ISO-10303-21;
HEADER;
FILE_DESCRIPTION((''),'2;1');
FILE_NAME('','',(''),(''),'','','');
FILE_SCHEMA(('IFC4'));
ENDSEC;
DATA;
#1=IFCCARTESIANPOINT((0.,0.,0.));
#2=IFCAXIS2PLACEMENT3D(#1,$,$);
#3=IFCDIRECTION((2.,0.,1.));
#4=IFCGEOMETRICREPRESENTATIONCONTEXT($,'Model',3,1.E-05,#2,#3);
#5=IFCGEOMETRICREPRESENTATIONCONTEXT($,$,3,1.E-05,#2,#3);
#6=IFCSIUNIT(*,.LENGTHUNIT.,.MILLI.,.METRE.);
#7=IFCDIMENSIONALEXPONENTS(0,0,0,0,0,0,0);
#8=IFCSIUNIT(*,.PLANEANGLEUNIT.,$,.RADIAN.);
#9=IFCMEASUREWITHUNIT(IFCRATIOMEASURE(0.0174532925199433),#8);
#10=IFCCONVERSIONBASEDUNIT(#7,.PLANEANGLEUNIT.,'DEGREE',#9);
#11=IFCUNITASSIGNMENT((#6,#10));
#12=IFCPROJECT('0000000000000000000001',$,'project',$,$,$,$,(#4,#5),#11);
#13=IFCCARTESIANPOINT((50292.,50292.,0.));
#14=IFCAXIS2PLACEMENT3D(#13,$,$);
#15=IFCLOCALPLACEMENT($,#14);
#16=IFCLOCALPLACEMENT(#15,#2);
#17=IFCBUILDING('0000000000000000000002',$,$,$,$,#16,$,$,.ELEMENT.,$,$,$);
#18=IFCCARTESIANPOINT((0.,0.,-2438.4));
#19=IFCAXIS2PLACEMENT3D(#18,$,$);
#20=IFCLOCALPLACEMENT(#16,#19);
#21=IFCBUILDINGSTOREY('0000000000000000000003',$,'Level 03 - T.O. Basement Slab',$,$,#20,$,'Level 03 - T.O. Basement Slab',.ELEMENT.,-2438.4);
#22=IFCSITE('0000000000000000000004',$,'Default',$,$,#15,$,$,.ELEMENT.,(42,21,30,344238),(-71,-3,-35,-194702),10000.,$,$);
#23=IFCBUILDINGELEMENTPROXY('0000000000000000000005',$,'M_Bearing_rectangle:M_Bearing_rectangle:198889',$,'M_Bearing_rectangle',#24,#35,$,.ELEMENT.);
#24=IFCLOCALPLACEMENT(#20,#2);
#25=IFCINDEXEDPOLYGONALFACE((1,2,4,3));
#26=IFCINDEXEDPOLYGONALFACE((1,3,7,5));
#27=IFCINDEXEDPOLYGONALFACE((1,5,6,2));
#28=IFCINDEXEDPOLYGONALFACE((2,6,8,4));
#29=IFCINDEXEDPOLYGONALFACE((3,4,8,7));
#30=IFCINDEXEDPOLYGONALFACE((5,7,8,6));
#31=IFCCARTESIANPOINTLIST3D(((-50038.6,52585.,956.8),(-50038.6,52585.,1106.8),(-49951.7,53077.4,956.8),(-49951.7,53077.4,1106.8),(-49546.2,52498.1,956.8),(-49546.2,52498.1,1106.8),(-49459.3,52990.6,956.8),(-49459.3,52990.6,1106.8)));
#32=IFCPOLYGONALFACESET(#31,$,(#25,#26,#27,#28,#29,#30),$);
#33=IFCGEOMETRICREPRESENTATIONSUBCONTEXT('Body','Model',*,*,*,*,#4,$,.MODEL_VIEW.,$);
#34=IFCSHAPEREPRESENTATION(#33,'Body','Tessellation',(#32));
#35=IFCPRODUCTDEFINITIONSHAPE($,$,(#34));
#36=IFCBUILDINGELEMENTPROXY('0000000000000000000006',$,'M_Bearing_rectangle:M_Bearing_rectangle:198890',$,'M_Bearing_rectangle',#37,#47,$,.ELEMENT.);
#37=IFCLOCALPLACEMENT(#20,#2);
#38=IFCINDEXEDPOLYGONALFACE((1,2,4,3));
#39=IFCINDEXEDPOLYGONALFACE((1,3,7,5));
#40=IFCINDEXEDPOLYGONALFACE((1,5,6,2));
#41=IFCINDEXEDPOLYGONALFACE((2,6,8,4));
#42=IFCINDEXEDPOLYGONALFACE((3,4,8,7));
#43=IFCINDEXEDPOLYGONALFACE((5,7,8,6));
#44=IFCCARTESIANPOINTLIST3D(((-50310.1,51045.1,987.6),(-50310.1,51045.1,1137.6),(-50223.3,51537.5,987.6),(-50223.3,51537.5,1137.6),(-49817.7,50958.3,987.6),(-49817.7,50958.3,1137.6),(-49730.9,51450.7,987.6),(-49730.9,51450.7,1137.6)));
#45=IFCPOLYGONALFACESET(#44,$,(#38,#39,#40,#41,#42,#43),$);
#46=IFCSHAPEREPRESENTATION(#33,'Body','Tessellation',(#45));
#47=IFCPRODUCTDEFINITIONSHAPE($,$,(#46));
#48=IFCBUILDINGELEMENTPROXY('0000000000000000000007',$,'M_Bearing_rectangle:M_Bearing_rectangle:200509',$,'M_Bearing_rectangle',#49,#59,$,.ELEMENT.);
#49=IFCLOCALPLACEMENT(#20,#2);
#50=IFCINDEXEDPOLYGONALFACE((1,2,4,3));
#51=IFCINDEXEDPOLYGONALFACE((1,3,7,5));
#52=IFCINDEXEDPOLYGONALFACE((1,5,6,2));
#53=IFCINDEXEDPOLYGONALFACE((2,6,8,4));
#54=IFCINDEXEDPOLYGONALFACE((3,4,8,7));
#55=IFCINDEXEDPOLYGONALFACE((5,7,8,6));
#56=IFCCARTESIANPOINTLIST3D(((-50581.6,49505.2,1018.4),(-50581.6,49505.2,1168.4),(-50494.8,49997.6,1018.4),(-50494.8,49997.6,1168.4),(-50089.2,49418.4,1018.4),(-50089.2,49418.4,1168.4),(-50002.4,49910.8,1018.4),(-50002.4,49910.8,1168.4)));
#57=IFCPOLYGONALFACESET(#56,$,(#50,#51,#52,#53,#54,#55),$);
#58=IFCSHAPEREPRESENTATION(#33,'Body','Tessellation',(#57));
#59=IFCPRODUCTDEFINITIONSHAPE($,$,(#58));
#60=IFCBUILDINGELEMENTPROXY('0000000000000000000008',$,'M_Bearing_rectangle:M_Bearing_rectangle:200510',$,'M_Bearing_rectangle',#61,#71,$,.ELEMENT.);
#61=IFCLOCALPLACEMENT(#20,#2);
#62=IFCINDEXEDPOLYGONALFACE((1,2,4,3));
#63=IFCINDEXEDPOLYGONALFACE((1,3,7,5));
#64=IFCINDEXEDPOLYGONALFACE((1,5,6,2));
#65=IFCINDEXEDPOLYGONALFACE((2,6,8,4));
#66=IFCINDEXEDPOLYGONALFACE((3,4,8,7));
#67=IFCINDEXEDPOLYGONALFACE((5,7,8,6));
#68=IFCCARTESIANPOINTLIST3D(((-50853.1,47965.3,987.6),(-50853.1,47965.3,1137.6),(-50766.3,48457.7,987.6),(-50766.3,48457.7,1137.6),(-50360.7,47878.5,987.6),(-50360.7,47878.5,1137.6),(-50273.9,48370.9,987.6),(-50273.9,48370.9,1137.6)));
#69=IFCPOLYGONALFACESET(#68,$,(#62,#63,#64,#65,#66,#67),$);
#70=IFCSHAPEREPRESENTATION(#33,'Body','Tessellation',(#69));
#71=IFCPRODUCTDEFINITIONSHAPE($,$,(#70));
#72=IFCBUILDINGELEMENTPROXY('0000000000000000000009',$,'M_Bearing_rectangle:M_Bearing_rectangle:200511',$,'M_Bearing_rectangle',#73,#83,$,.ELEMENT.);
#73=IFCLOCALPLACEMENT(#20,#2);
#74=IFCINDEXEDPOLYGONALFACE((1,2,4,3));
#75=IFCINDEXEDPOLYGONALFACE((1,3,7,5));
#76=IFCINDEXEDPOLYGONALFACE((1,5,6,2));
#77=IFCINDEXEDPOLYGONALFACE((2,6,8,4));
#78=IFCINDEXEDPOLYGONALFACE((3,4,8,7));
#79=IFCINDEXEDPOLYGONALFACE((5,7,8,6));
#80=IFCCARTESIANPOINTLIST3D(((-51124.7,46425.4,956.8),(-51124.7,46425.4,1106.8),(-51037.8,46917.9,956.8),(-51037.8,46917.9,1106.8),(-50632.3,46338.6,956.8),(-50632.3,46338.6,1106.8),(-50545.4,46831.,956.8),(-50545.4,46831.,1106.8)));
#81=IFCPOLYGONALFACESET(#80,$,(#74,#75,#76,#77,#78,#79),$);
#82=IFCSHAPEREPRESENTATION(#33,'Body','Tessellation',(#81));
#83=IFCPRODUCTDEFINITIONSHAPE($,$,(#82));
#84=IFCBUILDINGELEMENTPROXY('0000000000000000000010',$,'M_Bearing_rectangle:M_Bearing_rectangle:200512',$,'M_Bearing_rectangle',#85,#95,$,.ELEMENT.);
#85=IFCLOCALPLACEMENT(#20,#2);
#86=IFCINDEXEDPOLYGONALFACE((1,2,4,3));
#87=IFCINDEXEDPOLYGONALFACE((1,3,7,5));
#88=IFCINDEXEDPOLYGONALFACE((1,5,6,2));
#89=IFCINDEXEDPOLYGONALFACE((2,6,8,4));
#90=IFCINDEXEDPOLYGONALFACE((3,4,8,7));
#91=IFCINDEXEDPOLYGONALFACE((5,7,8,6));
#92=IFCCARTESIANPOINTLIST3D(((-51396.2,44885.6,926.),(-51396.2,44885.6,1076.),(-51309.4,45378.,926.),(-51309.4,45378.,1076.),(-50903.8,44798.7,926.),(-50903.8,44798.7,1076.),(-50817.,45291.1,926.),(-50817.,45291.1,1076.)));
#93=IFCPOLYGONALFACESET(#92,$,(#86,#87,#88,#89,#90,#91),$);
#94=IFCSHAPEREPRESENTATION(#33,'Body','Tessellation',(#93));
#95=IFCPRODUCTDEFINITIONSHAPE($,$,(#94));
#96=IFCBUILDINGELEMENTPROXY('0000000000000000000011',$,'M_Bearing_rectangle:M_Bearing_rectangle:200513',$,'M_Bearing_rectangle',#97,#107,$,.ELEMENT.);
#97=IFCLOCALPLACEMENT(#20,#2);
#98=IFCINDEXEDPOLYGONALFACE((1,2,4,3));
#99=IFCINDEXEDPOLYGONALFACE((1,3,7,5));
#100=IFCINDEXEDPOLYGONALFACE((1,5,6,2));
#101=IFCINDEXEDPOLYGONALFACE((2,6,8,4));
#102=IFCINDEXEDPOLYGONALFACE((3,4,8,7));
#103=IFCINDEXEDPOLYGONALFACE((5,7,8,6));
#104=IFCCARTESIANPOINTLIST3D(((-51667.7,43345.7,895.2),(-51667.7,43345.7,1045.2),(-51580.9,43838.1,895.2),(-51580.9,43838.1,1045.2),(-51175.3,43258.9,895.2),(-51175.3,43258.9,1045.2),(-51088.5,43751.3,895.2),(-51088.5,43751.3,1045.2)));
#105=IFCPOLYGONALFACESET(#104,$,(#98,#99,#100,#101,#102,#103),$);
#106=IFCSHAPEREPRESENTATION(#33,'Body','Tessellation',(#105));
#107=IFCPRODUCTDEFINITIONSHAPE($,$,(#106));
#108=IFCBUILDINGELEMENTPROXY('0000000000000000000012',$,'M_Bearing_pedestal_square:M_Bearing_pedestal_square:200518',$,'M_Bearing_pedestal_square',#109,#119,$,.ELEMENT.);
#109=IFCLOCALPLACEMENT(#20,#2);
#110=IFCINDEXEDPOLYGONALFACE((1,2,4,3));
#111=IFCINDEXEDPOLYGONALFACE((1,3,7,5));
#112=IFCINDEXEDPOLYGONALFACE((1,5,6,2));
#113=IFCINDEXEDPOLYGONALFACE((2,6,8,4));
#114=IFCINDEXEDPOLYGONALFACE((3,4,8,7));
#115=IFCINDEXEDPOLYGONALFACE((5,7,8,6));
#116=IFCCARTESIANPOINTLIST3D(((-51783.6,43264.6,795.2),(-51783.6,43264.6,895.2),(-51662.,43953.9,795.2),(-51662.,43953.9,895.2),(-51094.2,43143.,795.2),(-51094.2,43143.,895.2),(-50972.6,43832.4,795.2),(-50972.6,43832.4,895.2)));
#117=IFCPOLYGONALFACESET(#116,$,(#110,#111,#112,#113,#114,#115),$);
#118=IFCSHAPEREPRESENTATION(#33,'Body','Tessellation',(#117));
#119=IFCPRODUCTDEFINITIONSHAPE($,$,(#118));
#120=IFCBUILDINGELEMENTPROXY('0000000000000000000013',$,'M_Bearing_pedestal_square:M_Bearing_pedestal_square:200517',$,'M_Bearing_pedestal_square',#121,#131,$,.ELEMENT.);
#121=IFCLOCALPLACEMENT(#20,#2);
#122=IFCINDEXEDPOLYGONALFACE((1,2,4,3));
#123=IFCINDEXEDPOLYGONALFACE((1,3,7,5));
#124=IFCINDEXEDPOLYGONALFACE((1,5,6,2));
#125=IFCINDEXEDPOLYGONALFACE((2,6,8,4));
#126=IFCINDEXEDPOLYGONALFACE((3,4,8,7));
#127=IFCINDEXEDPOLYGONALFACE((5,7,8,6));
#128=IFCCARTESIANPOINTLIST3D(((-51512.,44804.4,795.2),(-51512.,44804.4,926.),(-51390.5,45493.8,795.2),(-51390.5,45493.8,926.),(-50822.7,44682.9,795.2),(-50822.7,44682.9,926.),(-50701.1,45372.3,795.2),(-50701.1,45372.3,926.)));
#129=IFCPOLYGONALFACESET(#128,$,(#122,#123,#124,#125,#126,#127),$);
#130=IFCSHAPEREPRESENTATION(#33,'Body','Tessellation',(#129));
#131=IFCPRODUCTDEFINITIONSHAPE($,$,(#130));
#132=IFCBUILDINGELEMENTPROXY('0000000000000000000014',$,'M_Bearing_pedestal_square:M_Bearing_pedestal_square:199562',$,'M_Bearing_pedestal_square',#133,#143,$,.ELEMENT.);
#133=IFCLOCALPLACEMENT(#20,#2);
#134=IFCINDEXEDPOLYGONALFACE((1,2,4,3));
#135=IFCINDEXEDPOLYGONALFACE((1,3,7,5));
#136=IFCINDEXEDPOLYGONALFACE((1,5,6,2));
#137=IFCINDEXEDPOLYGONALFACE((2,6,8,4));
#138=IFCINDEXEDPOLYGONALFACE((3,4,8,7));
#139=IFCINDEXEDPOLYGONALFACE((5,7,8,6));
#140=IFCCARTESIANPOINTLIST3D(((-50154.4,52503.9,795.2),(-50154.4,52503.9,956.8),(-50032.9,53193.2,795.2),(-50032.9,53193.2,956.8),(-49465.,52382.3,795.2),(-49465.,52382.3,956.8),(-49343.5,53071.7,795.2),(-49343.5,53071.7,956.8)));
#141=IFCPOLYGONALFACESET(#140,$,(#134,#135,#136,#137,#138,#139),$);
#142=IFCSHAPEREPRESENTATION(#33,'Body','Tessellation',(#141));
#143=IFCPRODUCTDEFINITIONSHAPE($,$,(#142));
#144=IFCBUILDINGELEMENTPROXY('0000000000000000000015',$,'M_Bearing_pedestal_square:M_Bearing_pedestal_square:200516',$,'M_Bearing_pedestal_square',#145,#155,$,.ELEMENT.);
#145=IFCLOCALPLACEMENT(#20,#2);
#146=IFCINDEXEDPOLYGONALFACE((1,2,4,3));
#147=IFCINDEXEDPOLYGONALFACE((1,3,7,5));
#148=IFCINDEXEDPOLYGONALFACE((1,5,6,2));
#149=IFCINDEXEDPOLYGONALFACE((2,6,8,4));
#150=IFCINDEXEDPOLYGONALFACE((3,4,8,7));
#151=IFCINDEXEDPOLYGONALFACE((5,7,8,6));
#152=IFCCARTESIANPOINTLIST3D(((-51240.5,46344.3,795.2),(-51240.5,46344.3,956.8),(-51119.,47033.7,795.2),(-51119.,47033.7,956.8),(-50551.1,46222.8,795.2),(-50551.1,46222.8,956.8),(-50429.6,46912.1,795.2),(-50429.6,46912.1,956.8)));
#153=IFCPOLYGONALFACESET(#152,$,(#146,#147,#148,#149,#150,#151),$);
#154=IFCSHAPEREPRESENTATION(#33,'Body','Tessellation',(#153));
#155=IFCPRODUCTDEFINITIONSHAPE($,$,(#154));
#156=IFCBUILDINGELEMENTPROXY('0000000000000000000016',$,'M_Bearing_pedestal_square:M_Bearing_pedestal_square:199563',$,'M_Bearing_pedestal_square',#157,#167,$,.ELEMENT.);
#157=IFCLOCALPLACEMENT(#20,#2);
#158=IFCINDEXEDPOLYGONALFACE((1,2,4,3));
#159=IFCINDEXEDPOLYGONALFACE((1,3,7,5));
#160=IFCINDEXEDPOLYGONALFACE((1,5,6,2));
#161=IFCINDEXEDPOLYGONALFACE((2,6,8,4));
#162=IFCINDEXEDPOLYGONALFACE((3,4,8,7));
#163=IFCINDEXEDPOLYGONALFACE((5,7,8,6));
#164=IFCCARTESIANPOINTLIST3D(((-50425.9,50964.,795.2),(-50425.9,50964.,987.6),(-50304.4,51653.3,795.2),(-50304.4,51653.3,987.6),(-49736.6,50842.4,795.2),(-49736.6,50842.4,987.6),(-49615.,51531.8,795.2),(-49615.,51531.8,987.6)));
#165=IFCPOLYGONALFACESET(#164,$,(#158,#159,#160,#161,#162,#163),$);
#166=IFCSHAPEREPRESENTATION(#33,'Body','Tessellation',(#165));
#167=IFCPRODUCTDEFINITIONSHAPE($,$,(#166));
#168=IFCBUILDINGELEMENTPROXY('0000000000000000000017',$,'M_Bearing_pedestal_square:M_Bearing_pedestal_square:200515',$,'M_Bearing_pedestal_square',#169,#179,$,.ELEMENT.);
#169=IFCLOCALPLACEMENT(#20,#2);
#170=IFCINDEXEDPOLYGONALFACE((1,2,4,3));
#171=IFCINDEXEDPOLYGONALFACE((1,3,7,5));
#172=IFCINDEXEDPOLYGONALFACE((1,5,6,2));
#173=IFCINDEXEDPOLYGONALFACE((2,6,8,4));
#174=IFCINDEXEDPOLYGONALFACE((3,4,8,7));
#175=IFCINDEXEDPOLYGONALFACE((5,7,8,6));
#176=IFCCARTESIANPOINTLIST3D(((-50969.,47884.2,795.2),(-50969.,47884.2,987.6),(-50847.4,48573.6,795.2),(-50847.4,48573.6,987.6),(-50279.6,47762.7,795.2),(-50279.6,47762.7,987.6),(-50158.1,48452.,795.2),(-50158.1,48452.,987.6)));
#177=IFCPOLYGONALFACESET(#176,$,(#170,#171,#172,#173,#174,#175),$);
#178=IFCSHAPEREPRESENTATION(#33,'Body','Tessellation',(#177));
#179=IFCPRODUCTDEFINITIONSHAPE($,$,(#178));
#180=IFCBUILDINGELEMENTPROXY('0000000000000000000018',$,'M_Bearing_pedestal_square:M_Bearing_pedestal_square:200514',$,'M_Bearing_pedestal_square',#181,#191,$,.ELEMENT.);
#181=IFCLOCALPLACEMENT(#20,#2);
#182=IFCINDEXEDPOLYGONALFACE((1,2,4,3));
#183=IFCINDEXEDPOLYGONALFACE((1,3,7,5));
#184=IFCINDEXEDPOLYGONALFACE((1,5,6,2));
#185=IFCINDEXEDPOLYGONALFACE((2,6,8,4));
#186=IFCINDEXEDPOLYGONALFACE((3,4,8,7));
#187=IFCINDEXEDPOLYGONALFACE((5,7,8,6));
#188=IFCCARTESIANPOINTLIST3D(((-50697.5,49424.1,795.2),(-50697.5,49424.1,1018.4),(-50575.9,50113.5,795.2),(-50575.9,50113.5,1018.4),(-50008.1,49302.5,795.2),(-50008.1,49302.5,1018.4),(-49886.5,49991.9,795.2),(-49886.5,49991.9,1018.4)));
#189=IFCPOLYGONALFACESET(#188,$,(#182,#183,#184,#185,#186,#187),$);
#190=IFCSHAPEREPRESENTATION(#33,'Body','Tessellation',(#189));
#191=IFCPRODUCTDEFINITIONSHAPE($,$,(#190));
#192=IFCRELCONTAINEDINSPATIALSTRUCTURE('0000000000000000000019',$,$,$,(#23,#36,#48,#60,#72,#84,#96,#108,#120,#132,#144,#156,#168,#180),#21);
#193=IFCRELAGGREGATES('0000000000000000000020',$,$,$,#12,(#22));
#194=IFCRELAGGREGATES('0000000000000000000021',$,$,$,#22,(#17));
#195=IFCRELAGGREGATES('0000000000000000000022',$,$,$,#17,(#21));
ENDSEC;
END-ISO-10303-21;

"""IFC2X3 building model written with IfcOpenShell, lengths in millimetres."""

from ifc_helpers import new_model, entity, si_unit, converted_unit, direction, frame, origin, origin_2d_with_axis, place, context, subcontext, project, spatial, rectangle, extrude, source, transform, mapped, element, save


model = new_model("IFC2X3")

# Units and contexts
model_context = context("Model", 3, precision=1e-05, world=origin(), true_north=direction((2.0, 0.0, 1.0)))
context_of_model = context(None, 3, precision=1e-05, world=origin(), true_north=direction((2.0, 0.0, 1.0)))
body_context = subcontext(model_context, "Body", "Model", "MODEL_VIEW")
ifc_project = project(units=[si_unit("LENGTHUNIT", "METRE", prefix="MILLI"), converted_unit("PLANEANGLEUNIT", "DEGREE", entity("IfcRatioMeasure", 0.0174532925199433), si_unit("PLANEANGLEUNIT", "RADIAN"), dimensions=[0, 0, 0, 0, 0, 0, 0])], contexts=[model_context, context_of_model])

# Site, building, storey
site_placement = place(None, frame((50292.0, 50292.0, 0.0)))
site = spatial("IfcSite", under=ifc_project, at=site_placement, Name="Default", CompositionType="ELEMENT", RefLatitude=(42, 21, 30, 344238), RefLongitude=(-71, -3, -35, -194702), RefElevation=10000.0)
building_placement = place(site_placement, origin())
building = spatial("IfcBuilding", under=site, at=building_placement, CompositionType="ELEMENT")
storey_placement = place(building_placement, frame((0.0, 0.0, -2438.4)))
storey = spatial("IfcBuildingStorey", under=building, at=storey_placement, Name="Level 03 - T.O. Basement Slab", LongName="Level 03 - T.O. Basement Slab", CompositionType="ELEMENT", Elevation=-2438.4)

# Building element proxies
shared_shape_1 = source(origin(), body_context, "Body", "SweptSolid", [
    extrude(rectangle(XDim=500.0, YDim=500.0, at=origin_2d_with_axis()), frame((0.0, 0.0, -150.0), z_axis=(0.0, 0.0, 1.0), x_axis=(-1.0, 0.0, 0.0)), (0.0, 0.0, 1.0), 150.0),
])
for number, where, z_axis, x_axis, name in (
    (1, (-49749.0, 52787.8, 1106.8), (0.0, 0.0, 1.0), (0.173648, 0.984808, 0.0), "M_Bearing_rectangle:M_Bearing_rectangle:198889"),
    (2, (-50020.5, 51247.9, 1137.6), (0.0, 0.0, 1.0), (0.173648, 0.984808, 0.0), "M_Bearing_rectangle:M_Bearing_rectangle:198890"),
    (3, (-50292.0, 49708.0, 1168.4), (0.0, 0.0, 1.0), (0.173648, 0.984808, 0.0), "M_Bearing_rectangle:M_Bearing_rectangle:200509"),
    (4, (-50563.5, 48168.1, 1137.6), (0.0, 0.0, 1.0), (0.173648, 0.984808, 0.0), "M_Bearing_rectangle:M_Bearing_rectangle:200510"),
    (5, (-50835.0, 46628.2, 1106.8), (0.0, 0.0, 1.0), (0.173648, 0.984808, 0.0), "M_Bearing_rectangle:M_Bearing_rectangle:200511"),
    (6, (-51106.6, 45088.4, 1076.0), (0.0, 0.0, 1.0), (0.173648, 0.984808, 0.0), "M_Bearing_rectangle:M_Bearing_rectangle:200512"),
    (7, (-51378.1, 43548.5, 1045.2), (0.0, 0.0, 1.0), (0.173648, 0.984808, 0.0), "M_Bearing_rectangle:M_Bearing_rectangle:200513"),
):
    element("IfcBuildingElementProxy", number, at=place(storey_placement, frame(where, z_axis=z_axis, x_axis=x_axis)), inside=storey, Name=name, ObjectType="M_Bearing_rectangle", CompositionType="ELEMENT", context=body_context, shape_type="MappedRepresentation", body=[
        mapped(shared_shape_1, transform((0.0, 0.0, 0.0), scale=1.0)),
    ])
shared_shape_2 = source(origin(), body_context, "Body", "SweptSolid", [
    extrude(rectangle(XDim=700.0, YDim=700.0, at=origin_2d_with_axis()), frame((0.0, 0.0, -100.0)), (0.0, 0.0, 1.0), 100.0),
])
proxy_1_placement = place(storey_placement, frame((-51378.1, 43548.5, 895.2), z_axis=(0.0, 0.0, 1.0), x_axis=(0.173648, 0.984808, 0.0)))
element("IfcBuildingElementProxy", 8, at=proxy_1_placement, inside=storey, Name="M_Bearing_pedestal_square:M_Bearing_pedestal_square:200518", ObjectType="M_Bearing_pedestal_square", CompositionType="ELEMENT", context=body_context, shape_type="MappedRepresentation", body=[
    mapped(shared_shape_2, transform((0.0, 0.0, 0.0), scale=1.0)),
])
shared_shape_3 = source(origin(), body_context, "Body", "SweptSolid", [
    extrude(rectangle(XDim=700.0, YDim=700.0, at=origin_2d_with_axis()), frame((0.0, 0.0, -130.8)), (0.0, 0.0, 1.0), 130.8),
])
proxy_2_placement = place(storey_placement, frame((-51106.6, 45088.4, 926.0), z_axis=(0.0, 0.0, 1.0), x_axis=(0.173648, 0.984808, 0.0)))
element("IfcBuildingElementProxy", 9, at=proxy_2_placement, inside=storey, Name="M_Bearing_pedestal_square:M_Bearing_pedestal_square:200517", ObjectType="M_Bearing_pedestal_square", CompositionType="ELEMENT", context=body_context, shape_type="MappedRepresentation", body=[
    mapped(shared_shape_3, transform((0.0, 0.0, 0.0), scale=1.0)),
])
shared_shape_4 = source(origin(), body_context, "Body", "SweptSolid", [
    extrude(rectangle(XDim=700.0, YDim=700.0, at=origin_2d_with_axis()), frame((0.0, 0.0, -161.6)), (0.0, 0.0, 1.0), 161.6),
])
for number, where, z_axis, x_axis, name in (
    (10, (-49749.0, 52787.8, 956.8), (0.0, 0.0, 1.0), (0.173648, 0.984808, 0.0), "M_Bearing_pedestal_square:M_Bearing_pedestal_square:199562"),
    (11, (-50835.0, 46628.2, 956.8), (0.0, 0.0, 1.0), (0.173648, 0.984808, 0.0), "M_Bearing_pedestal_square:M_Bearing_pedestal_square:200516"),
):
    element("IfcBuildingElementProxy", number, at=place(storey_placement, frame(where, z_axis=z_axis, x_axis=x_axis)), inside=storey, Name=name, ObjectType="M_Bearing_pedestal_square", CompositionType="ELEMENT", context=body_context, shape_type="MappedRepresentation", body=[
        mapped(shared_shape_4, transform((0.0, 0.0, 0.0), scale=1.0)),
    ])
shared_shape_5 = source(origin(), body_context, "Body", "SweptSolid", [
    extrude(rectangle(XDim=700.0, YDim=700.0, at=origin_2d_with_axis()), frame((0.0, 0.0, -192.4)), (0.0, 0.0, 1.0), 192.4),
])
for number, where, z_axis, x_axis, name in (
    (12, (-50020.5, 51247.9, 987.6), (0.0, 0.0, 1.0), (0.173648, 0.984808, 0.0), "M_Bearing_pedestal_square:M_Bearing_pedestal_square:199563"),
    (13, (-50563.5, 48168.1, 987.6), (0.0, 0.0, 1.0), (0.173648, 0.984808, 0.0), "M_Bearing_pedestal_square:M_Bearing_pedestal_square:200515"),
):
    element("IfcBuildingElementProxy", number, at=place(storey_placement, frame(where, z_axis=z_axis, x_axis=x_axis)), inside=storey, Name=name, ObjectType="M_Bearing_pedestal_square", CompositionType="ELEMENT", context=body_context, shape_type="MappedRepresentation", body=[
        mapped(shared_shape_5, transform((0.0, 0.0, 0.0), scale=1.0)),
    ])
shared_shape_6 = source(origin(), body_context, "Body", "SweptSolid", [
    extrude(rectangle(XDim=700.0, YDim=700.0, at=origin_2d_with_axis()), frame((0.0, 0.0, -223.2)), (0.0, 0.0, 1.0), 223.2),
])
proxy_3_placement = place(storey_placement, frame((-50292.0, 49708.0, 1018.4), z_axis=(0.0, 0.0, 1.0), x_axis=(0.173648, 0.984808, 0.0)))
element("IfcBuildingElementProxy", 14, at=proxy_3_placement, inside=storey, Name="M_Bearing_pedestal_square:M_Bearing_pedestal_square:200514", ObjectType="M_Bearing_pedestal_square", CompositionType="ELEMENT", context=body_context, shape_type="MappedRepresentation", body=[
    mapped(shared_shape_6, transform((0.0, 0.0, 0.0), scale=1.0)),
])

save(model, "model.ifc")
